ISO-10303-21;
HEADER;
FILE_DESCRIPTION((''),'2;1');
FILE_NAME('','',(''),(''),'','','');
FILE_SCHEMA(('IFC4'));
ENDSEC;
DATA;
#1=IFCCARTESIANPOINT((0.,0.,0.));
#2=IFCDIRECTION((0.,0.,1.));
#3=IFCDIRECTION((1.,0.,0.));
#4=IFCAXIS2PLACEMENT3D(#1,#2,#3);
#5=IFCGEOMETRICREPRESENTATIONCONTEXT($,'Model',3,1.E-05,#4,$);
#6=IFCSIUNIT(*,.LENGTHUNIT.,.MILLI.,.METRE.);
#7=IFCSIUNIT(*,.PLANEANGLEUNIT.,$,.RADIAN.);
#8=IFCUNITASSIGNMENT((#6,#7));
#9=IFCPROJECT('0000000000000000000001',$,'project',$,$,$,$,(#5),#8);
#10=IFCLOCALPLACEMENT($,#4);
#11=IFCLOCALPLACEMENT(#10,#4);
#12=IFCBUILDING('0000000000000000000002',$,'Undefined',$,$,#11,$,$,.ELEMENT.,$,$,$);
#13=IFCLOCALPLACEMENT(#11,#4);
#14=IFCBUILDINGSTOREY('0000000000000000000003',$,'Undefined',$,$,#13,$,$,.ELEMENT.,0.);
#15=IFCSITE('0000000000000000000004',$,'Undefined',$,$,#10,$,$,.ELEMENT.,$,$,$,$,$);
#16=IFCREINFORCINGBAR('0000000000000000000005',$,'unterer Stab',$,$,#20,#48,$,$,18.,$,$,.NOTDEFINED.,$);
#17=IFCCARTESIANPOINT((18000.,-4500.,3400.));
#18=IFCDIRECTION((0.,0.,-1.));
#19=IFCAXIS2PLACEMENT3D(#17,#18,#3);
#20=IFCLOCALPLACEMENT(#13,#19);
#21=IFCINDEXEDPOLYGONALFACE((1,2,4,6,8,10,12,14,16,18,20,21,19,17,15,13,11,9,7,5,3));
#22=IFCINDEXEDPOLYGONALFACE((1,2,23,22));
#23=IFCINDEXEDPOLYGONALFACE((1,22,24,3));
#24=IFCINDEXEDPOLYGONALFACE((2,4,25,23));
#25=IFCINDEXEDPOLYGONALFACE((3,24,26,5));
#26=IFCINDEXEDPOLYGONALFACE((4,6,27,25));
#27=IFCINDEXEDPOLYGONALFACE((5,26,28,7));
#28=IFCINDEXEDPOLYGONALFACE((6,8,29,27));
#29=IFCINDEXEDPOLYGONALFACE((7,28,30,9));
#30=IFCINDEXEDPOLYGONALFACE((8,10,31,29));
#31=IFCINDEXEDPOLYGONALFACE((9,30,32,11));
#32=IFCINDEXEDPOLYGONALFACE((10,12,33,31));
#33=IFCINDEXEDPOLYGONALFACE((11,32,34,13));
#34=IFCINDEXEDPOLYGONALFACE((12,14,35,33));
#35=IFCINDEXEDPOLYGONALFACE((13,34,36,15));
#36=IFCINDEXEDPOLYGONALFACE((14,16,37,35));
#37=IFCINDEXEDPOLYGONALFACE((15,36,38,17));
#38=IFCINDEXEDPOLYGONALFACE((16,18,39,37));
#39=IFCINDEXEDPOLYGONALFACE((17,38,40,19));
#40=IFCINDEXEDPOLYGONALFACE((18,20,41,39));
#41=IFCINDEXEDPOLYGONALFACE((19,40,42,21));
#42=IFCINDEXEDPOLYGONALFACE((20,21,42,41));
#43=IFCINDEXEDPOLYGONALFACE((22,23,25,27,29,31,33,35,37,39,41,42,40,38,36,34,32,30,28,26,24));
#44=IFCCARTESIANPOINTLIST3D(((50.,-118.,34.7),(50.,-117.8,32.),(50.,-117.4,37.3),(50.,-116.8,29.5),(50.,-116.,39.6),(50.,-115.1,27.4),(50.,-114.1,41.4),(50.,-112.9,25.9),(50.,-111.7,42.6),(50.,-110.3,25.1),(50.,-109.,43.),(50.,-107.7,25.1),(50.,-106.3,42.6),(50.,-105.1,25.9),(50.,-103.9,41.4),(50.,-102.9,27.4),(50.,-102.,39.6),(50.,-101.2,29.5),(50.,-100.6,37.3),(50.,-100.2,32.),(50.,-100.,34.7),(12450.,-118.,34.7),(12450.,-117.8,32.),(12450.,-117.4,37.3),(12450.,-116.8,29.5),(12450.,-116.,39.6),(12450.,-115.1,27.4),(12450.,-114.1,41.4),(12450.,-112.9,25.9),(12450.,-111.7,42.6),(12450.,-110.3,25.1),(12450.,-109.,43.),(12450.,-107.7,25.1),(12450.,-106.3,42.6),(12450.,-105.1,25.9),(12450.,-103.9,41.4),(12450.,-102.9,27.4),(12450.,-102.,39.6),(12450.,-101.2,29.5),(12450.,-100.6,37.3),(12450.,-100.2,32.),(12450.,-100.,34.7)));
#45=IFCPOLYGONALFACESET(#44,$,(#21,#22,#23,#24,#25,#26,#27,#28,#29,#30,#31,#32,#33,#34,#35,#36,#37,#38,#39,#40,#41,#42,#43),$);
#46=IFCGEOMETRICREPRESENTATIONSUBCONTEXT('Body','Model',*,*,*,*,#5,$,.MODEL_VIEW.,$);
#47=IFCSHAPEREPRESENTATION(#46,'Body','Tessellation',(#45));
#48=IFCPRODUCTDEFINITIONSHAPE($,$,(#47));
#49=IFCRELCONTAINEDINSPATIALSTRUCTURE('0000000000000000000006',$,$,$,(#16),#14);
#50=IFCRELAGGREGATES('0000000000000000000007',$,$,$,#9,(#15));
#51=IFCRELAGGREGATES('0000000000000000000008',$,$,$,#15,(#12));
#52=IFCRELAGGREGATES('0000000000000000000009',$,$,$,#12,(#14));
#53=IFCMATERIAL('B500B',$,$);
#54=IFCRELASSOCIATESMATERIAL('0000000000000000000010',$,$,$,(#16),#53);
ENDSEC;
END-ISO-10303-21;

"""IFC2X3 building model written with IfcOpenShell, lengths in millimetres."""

from ifc_helpers import new_model, entity, si_unit, frame, origin_with_axes, place, context, subcontext, project, spatial, source, transform, mapped, material, element, save


model = new_model("IFC2X3")

# Units and contexts
model_context = context("Model", 3, precision=1e-05, world=origin_with_axes())
body_context = subcontext(model_context, "Body", "Model", "MODEL_VIEW")
ifc_project = project(units=[si_unit("LENGTHUNIT", "METRE", prefix="MILLI"), si_unit("PLANEANGLEUNIT", "RADIAN")], contexts=[model_context])

# Site, building, storey
site_placement = place(None, origin_with_axes())
site = spatial("IfcSite", under=ifc_project, at=site_placement, Name="Undefined", CompositionType="ELEMENT")
building_placement = place(site_placement, origin_with_axes())
building = spatial("IfcBuilding", under=site, at=building_placement, Name="Undefined", CompositionType="ELEMENT")
storey_placement = place(building_placement, origin_with_axes())
storey = spatial("IfcBuildingStorey", under=building, at=storey_placement, Name="Undefined", CompositionType="ELEMENT", Elevation=0.0)

# Shared definitions
ifc_material_1 = material(Name="B500B")

# Reinforcing bar
shared_shape_1 = source(origin_with_axes(), body_context, "Body", "AdvancedSweptSolid", [
    entity("IfcSweptDiskSolid", entity("IfcTrimmedCurve", entity("IfcLine", entity("IfcCartesianPoint", [0.0, 0.0, 0.0]), entity("IfcVector", entity("IfcDirection", [1.0, 0.0, 0.0]), 1.0)), [entity("IfcParameterValue", 0.0)], [entity("IfcParameterValue", 12400.0)], True, "PARAMETER"), 9.0, None, 0.0, 12400.0),
])
reinforcing_bar_1_placement = place(storey_placement, frame((18000.0, -4500.0, 3400.0), z_axis=(0.0, 0.0, -1.0), x_axis=(1.0, 0.0, 0.0)))
element("IfcReinforcingBar", 1, at=reinforcing_bar_1_placement, inside=storey, material=ifc_material_1, Name="unterer Stab", BarRole="NOTDEFINED", NominalDiameter=18.0, context=body_context, shape_type="MappedRepresentation", body=[
    mapped(shared_shape_1, transform((50.0, -109.0, 34.0))),
])

save(model, "model.ifc")
